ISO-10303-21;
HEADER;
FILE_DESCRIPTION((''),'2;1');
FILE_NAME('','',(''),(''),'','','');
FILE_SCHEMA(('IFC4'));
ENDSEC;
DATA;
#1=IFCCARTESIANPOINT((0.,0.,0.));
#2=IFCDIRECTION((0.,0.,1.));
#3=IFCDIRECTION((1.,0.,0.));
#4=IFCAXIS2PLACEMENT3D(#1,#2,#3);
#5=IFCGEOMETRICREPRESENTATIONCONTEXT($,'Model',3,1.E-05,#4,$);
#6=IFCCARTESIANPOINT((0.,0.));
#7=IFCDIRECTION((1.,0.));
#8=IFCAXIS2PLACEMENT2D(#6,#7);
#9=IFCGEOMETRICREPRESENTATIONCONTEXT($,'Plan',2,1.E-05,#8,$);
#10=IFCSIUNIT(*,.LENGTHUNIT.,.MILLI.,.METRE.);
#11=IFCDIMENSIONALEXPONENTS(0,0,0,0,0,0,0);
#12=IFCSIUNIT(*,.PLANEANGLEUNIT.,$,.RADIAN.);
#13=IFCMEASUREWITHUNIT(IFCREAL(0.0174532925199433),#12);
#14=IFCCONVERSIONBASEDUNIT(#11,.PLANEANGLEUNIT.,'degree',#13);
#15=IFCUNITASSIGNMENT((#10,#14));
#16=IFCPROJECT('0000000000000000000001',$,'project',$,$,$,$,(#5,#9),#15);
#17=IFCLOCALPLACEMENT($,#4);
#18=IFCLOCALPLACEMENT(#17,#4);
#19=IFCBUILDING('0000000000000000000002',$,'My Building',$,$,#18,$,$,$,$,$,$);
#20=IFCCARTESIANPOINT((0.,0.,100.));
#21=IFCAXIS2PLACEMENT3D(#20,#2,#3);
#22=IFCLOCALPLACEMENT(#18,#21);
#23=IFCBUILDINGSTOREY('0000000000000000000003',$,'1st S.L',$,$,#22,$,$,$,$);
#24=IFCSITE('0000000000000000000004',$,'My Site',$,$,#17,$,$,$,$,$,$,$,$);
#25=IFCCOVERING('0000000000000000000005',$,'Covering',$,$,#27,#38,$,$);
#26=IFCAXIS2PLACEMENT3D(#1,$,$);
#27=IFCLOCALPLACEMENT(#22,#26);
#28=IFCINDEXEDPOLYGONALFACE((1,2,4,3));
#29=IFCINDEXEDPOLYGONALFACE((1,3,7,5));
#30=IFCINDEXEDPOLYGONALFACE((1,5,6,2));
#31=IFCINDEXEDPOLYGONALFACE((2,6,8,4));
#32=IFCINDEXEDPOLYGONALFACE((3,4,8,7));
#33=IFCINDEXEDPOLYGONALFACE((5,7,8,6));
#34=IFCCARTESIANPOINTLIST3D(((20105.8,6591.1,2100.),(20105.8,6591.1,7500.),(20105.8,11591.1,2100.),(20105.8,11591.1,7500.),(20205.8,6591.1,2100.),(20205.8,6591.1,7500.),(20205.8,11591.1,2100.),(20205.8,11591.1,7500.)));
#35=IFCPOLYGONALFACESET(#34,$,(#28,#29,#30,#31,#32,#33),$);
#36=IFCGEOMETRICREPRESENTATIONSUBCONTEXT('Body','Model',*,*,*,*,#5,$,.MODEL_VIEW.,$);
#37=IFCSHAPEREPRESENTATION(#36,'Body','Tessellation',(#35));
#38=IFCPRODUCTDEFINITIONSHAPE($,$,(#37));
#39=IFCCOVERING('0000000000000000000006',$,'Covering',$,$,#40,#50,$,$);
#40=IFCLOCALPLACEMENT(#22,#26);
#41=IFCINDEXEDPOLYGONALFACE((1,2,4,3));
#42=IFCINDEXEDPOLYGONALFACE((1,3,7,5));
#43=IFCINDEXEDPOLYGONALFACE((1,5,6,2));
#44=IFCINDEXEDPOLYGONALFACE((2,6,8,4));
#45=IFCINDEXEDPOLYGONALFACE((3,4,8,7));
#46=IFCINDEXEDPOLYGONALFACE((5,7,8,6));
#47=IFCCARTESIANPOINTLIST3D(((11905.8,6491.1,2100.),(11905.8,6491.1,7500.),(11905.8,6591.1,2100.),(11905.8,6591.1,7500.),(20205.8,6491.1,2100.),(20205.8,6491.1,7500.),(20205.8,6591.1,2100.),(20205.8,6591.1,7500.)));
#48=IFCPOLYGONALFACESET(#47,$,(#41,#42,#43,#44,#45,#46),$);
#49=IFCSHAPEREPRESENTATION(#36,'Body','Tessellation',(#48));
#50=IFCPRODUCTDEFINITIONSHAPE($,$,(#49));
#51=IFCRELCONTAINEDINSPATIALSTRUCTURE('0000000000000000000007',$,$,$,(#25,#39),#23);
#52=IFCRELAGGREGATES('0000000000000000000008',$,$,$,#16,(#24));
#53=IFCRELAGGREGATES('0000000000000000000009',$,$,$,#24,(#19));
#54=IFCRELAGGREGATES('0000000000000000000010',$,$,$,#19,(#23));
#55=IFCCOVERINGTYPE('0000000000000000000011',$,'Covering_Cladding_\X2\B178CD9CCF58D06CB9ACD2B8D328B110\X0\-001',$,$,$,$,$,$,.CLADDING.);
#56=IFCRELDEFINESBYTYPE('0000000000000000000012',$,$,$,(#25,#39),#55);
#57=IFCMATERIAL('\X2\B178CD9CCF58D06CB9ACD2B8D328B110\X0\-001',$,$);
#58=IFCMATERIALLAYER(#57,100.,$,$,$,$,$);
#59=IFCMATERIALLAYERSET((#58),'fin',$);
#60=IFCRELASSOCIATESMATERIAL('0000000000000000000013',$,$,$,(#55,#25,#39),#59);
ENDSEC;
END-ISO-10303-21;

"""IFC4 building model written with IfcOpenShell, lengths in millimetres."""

from ifc_helpers import new_model, entity, si_unit, converted_unit, frame, origin_with_axes, origin_2d_with_axis, place, context, subcontext, project, spatial, indexed_curve, outline, extrude, material, layer, layer_set, layer_usage, type_object, element, save


model = new_model("IFC4")

# Units and contexts
model_context = context("Model", 3, precision=1e-05, world=origin_with_axes())
plan_context = context("Plan", 2, precision=1e-05, world=origin_2d_with_axis())
body_context_1 = subcontext(model_context, "Body", "Model", "MODEL_VIEW")
ifc_project = project(units=[si_unit("LENGTHUNIT", "METRE", prefix="MILLI"), converted_unit("PLANEANGLEUNIT", "degree", entity("IfcReal", 0.0174532925199433), si_unit("PLANEANGLEUNIT", "RADIAN"), dimensions=[0, 0, 0, 0, 0, 0, 0])], contexts=[model_context, plan_context])

# Site, building, storey
site_placement = place(None, origin_with_axes())
site = spatial("IfcSite", under=ifc_project, at=site_placement, Name="My Site")
building_placement = place(site_placement, origin_with_axes())
building = spatial("IfcBuilding", under=site, at=building_placement, Name="My Building")
storey_placement = place(building_placement, frame((0.0, 0.0, 100.0), z_axis=(0.0, 0.0, 1.0), x_axis=(1.0, 0.0, 0.0)))
storey = spatial("IfcBuildingStorey", under=building, at=storey_placement, Name="1st S.L")

# Coverings
ifc_material_1 = material(Name="노출콘크리트패널-001")
ifc_layer_1 = layer(ifc_material_1, 100.0)
ifc_layer_set_1 = layer_set([ifc_layer_1], Name="fin")
covering_type = type_object("IfcCoveringType", Name="Covering_Cladding_노출콘크리트패널-001", PredefinedType="CLADDING", material=ifc_layer_set_1)
ifc_layer_usage_1 = layer_usage(ifc_layer_set_1, "AXIS2", "POSITIVE", 0.0)
covering_1_placement = place(storey_placement, frame((20105.8, 11591.1, 2100.0), z_axis=(0.0, 0.0, 1.0), x_axis=(-0.000001, -1.0, 0.0)))
element("IfcCovering", 1, at=covering_1_placement, inside=storey, type_object=covering_type, material=ifc_layer_usage_1, Name="Covering", context=body_context_1, shape_type="SweptSolid", body=[
    extrude(outline(indexed_curve([(0.0, 0.0), (0.0, 100.0), (5000.0, 100.0), (5000.0, 0.0), (0.0, 0.0)], self_intersect=False)), origin_with_axes(), (0.0, 0.0, 1.0), 5400.0),
])
ifc_layer_usage_2 = layer_usage(ifc_layer_set_1, "AXIS2", "POSITIVE", 0.0)
covering_2_placement = place(storey_placement, frame((20205.8, 6591.1, 2100.0), z_axis=(0.0, 0.0, 1.0), x_axis=(-1.0, 0.000001, 0.0)))
element("IfcCovering", 2, at=covering_2_placement, inside=storey, type_object=covering_type, material=ifc_layer_usage_2, Name="Covering", context=body_context_1, shape_type="SweptSolid", body=[
    extrude(outline(indexed_curve([(0.0, 0.0), (0.0, 100.0), (8300.0, 100.0), (8300.0, 0.0), (0.0, 0.0)], self_intersect=False)), origin_with_axes(), (0.0, 0.0, 1.0), 5400.0),
])

save(model, "model.ifc")
